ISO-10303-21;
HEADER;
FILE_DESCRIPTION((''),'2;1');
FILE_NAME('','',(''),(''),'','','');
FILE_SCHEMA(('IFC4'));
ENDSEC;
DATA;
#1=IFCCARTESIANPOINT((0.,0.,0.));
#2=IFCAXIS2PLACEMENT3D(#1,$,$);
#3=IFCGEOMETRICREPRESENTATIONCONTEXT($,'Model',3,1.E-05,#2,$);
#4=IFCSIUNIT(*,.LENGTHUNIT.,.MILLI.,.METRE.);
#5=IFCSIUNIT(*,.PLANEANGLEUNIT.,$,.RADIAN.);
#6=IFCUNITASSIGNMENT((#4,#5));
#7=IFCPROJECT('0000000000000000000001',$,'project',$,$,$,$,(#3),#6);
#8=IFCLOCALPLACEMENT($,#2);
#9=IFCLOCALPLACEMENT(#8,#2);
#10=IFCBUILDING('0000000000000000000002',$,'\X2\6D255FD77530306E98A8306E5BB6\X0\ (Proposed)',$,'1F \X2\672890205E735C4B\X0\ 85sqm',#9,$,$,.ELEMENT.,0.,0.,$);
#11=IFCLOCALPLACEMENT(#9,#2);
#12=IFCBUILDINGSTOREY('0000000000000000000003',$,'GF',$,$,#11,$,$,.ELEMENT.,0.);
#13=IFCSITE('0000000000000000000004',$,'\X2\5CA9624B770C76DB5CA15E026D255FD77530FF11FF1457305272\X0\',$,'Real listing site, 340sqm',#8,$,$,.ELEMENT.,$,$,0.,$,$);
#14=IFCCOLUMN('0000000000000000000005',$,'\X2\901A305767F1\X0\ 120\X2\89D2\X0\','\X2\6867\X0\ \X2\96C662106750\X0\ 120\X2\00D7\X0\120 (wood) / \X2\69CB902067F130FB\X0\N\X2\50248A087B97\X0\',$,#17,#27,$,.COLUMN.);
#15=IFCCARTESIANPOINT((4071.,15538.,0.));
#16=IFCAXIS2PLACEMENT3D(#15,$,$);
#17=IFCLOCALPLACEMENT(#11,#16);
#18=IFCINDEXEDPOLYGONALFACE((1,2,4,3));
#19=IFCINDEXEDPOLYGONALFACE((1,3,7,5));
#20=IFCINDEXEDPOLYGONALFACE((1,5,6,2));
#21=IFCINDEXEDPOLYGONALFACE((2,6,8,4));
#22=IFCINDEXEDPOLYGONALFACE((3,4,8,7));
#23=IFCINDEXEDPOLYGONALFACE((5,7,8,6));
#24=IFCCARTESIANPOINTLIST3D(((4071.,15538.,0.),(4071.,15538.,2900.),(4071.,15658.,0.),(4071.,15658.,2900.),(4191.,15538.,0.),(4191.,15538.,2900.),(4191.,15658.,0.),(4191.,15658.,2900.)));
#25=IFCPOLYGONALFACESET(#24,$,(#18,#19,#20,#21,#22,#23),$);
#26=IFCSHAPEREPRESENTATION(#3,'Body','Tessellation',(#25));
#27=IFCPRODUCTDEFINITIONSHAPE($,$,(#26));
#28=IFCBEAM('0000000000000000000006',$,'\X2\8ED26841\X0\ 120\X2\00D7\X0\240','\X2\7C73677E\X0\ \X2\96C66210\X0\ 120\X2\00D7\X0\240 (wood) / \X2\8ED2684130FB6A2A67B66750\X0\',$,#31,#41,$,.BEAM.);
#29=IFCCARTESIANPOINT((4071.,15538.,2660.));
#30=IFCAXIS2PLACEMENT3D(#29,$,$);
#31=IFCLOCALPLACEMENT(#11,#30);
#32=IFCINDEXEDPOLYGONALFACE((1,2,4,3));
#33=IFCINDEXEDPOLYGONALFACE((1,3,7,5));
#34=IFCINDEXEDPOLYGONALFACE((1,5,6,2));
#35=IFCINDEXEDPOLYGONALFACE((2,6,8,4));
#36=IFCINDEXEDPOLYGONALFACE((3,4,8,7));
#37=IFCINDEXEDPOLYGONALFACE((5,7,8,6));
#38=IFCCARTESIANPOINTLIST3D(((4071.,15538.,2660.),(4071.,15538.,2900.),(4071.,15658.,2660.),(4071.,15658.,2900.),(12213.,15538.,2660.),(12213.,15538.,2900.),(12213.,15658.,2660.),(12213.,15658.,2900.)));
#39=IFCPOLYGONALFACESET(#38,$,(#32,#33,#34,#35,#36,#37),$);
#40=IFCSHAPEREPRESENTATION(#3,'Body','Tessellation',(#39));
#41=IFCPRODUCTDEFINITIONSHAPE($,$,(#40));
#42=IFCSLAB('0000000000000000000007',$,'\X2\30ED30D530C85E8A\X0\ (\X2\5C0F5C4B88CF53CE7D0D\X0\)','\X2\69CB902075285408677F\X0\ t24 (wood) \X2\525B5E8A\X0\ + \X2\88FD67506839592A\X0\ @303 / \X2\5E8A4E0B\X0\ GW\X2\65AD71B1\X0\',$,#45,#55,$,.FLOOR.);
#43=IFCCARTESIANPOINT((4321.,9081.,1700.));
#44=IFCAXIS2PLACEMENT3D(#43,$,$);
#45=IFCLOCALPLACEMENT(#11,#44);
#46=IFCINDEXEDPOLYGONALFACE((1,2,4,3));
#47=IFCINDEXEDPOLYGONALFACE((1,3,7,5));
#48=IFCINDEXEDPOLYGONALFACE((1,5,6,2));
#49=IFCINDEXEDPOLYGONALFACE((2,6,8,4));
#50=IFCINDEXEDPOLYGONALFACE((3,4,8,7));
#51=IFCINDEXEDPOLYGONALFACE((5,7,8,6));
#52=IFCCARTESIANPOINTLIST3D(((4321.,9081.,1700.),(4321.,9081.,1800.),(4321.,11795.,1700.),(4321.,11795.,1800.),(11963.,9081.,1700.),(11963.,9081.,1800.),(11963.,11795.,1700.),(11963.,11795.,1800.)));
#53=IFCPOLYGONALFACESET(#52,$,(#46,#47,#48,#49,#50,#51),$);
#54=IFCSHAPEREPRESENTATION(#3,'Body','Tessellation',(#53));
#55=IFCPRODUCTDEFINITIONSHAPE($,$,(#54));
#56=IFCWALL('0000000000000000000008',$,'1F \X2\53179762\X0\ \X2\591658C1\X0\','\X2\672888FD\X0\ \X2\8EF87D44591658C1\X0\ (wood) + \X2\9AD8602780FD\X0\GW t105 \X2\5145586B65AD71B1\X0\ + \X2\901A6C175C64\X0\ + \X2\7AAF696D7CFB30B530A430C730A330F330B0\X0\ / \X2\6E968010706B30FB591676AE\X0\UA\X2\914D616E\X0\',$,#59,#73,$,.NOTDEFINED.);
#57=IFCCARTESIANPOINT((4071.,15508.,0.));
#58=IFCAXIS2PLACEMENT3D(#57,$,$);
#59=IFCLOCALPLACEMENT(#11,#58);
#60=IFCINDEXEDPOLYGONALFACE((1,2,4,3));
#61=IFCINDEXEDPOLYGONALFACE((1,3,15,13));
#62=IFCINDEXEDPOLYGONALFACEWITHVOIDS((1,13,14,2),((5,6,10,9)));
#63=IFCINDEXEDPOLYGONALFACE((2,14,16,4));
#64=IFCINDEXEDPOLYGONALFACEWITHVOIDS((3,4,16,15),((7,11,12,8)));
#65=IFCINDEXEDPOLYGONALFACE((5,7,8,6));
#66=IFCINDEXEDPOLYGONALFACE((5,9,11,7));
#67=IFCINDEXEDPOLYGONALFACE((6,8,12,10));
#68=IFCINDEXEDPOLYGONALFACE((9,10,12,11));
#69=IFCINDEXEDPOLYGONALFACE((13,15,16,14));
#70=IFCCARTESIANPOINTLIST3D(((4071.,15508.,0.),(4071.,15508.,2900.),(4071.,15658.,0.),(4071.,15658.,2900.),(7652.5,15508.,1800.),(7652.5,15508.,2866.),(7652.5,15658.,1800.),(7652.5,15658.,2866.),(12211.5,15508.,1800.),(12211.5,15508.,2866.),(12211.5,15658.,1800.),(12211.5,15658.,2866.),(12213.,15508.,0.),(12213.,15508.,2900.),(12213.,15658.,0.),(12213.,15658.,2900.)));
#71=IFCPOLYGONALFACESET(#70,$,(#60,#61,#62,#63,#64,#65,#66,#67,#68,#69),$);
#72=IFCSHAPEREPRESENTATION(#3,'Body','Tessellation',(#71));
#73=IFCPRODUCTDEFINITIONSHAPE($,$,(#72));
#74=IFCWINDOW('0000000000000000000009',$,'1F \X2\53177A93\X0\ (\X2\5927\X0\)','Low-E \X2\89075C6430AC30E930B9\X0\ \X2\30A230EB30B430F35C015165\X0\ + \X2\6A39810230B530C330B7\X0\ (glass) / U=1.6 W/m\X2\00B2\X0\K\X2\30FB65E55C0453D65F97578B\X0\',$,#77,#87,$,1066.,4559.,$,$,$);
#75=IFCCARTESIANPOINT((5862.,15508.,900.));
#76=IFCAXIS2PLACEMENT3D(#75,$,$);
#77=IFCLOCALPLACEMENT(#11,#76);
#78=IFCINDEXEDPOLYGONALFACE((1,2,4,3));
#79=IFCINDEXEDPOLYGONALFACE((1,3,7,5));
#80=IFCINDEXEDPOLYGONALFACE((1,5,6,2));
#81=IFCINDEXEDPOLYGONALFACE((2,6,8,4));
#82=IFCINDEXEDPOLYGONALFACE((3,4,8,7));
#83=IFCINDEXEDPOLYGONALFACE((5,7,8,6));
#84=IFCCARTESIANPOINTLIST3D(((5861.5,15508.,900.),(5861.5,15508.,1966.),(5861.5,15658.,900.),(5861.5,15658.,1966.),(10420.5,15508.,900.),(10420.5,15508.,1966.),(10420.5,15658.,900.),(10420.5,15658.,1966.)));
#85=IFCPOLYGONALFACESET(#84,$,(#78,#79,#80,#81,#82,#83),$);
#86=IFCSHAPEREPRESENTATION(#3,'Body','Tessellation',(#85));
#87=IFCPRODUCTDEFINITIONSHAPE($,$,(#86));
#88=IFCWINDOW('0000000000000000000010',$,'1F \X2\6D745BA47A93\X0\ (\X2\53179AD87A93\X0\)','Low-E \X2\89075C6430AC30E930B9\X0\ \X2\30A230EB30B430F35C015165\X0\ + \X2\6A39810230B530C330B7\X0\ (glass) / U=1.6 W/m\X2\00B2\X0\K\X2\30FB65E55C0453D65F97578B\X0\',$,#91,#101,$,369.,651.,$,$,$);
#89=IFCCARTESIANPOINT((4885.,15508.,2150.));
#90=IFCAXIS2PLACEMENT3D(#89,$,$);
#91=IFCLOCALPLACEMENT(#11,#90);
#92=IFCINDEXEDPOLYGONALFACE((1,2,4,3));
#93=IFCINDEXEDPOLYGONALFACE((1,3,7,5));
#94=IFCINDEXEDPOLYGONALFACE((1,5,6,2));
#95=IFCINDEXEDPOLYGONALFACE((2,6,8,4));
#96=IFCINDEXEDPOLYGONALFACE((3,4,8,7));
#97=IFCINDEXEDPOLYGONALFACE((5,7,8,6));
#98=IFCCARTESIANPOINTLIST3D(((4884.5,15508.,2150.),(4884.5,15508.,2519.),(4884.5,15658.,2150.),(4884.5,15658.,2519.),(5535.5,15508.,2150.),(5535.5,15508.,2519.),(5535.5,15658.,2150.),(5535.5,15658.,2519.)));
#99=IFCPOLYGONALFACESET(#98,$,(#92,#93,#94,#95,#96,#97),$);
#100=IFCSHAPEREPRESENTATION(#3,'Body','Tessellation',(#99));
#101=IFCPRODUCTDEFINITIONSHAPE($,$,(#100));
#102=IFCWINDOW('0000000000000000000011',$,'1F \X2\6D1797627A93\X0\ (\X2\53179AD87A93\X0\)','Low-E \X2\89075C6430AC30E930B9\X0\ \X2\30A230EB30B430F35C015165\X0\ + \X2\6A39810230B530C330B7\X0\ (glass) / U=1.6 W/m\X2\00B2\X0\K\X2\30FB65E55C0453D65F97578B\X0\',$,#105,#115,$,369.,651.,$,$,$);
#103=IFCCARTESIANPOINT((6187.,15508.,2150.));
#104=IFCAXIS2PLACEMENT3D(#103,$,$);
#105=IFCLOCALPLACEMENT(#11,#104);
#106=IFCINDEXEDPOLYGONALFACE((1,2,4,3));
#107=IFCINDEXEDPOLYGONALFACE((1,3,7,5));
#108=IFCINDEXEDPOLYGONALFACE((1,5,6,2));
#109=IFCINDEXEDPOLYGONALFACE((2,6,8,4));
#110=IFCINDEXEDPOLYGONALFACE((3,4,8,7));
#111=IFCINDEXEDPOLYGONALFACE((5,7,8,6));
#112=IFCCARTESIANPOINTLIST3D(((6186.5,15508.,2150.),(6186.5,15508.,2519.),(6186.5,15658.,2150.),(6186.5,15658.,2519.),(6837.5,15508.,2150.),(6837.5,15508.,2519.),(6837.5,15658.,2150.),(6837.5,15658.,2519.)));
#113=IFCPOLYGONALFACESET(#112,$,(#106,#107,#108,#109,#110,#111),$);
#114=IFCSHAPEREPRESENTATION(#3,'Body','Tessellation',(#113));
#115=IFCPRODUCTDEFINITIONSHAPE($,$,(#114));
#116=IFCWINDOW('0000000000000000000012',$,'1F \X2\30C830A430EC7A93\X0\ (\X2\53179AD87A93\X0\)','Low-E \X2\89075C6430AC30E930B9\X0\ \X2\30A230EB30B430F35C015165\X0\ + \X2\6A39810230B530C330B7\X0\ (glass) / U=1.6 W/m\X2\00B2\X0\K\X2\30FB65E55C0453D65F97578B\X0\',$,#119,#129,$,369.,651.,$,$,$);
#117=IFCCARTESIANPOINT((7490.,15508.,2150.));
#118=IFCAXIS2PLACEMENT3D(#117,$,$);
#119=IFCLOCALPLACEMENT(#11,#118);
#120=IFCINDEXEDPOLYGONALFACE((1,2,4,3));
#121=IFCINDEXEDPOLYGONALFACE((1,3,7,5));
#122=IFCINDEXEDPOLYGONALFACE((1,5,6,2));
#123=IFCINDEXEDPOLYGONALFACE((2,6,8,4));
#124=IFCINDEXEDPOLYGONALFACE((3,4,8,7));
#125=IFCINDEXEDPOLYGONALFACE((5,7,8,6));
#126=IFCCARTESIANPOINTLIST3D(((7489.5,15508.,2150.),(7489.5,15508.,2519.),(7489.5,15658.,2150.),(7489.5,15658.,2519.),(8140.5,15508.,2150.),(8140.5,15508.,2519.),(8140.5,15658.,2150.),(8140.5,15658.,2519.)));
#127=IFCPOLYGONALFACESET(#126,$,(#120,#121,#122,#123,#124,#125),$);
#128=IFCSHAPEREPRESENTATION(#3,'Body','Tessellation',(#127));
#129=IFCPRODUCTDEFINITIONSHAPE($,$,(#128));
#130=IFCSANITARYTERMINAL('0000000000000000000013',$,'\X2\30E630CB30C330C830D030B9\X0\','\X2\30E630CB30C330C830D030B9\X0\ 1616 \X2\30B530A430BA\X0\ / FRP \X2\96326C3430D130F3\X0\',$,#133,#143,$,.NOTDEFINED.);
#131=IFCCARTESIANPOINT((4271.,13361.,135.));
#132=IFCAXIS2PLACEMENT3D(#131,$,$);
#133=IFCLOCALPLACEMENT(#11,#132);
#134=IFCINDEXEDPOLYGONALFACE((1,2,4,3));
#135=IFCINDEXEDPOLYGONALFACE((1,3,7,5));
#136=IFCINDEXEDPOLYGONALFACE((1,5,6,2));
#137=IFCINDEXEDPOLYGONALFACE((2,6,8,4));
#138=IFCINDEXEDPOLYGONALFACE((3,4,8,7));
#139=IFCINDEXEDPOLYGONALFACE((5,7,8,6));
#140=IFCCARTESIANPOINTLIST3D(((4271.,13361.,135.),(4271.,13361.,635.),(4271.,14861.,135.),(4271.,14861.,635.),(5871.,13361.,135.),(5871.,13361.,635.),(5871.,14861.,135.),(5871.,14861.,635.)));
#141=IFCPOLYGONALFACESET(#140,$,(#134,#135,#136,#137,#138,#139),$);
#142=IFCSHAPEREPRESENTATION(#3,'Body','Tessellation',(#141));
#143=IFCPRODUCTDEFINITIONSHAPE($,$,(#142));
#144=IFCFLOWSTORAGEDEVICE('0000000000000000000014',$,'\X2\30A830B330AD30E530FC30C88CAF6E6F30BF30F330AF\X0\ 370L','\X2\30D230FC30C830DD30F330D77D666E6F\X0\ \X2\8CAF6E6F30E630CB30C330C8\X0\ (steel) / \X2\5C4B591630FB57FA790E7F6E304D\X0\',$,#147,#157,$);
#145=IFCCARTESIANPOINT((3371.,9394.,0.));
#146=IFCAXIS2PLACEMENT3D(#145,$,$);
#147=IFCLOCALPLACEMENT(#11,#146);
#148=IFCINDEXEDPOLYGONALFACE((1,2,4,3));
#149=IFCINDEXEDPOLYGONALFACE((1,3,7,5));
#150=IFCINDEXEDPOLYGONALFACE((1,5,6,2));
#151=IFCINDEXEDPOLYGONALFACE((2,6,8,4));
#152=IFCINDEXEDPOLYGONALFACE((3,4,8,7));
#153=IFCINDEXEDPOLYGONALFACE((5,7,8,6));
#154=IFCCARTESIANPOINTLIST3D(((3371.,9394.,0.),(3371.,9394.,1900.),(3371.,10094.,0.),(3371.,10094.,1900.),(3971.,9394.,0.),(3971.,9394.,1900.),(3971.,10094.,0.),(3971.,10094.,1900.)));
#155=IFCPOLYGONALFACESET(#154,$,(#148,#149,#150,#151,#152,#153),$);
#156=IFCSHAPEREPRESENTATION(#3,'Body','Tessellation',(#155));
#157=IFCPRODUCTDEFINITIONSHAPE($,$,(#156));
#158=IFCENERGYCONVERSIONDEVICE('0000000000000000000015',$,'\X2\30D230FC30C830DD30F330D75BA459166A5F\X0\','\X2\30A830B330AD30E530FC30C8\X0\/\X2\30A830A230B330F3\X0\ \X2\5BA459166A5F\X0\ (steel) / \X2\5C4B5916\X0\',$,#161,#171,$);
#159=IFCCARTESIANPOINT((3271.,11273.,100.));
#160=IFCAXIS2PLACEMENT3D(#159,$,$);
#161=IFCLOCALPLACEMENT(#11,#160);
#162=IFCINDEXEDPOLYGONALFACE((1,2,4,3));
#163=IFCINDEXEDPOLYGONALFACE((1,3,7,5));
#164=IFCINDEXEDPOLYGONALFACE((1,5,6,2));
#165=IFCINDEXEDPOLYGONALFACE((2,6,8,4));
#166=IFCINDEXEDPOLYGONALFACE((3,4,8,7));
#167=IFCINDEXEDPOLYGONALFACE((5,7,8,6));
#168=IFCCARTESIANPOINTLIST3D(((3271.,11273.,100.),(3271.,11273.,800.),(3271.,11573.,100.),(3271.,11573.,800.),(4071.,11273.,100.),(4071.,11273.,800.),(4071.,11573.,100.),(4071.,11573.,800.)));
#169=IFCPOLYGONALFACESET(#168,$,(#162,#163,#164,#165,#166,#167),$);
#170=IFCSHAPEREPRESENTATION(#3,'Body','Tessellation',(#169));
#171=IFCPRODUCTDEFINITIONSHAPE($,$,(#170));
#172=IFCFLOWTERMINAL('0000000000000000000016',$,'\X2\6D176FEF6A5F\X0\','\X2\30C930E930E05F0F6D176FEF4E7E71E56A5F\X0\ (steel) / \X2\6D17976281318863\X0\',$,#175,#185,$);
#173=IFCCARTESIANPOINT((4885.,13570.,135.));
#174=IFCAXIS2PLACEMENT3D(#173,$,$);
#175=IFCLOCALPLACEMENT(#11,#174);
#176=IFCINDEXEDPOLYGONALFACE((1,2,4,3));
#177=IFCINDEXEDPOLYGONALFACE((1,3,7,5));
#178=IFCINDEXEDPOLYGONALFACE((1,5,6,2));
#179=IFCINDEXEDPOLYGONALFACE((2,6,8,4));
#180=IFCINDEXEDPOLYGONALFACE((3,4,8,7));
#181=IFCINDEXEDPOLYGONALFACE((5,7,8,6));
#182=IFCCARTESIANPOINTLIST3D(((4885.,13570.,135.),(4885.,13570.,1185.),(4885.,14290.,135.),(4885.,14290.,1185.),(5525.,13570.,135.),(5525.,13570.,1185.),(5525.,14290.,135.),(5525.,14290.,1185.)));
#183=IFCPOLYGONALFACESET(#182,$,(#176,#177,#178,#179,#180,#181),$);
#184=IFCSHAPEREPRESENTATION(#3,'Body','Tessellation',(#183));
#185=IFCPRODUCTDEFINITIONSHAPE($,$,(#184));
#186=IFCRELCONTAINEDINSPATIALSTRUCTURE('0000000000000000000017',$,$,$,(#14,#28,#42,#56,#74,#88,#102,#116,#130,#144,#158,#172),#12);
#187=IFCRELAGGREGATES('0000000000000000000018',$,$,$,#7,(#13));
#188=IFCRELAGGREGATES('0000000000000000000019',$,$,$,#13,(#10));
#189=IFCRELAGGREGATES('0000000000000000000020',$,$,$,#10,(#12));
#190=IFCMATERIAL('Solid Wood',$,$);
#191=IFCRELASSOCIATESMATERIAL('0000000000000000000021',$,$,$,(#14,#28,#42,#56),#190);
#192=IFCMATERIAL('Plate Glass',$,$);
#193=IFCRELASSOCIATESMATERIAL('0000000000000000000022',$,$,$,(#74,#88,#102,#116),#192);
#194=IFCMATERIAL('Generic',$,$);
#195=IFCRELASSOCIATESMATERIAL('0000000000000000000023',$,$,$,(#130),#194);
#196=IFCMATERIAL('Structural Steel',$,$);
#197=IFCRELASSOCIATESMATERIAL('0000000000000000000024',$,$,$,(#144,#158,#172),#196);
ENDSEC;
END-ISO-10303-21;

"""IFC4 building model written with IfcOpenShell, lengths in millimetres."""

from ifc_helpers import new_model, si_unit, frame, frame_2d, origin, place, context, project, spatial, rectangle, extrude, material, element, fill, save


model = new_model("IFC4")

# Units and contexts
model_context = context("Model", 3, precision=1e-05, world=origin())
ifc_project = project(units=[si_unit("LENGTHUNIT", "METRE", prefix="MILLI"), si_unit("PLANEANGLEUNIT", "RADIAN")], contexts=[model_context])

# Site, building, storey
site_placement = place(None, origin())
site = spatial("IfcSite", under=ifc_project, at=site_placement, Name="岩手県盛岡市津志田１４地割", ObjectType="Real listing site, 340sqm", CompositionType="ELEMENT", RefElevation=0.0)
building_placement = place(site_placement, origin())
building = spatial("IfcBuilding", under=site, at=building_placement, Name="津志田の風の家 (Proposed)", ObjectType="1F 木造平屋 85sqm", CompositionType="ELEMENT", ElevationOfRefHeight=0.0, ElevationOfTerrain=0.0)
storey_placement = place(building_placement, origin())
storey = spatial("IfcBuildingStorey", under=building, at=storey_placement, Name="GF", CompositionType="ELEMENT", Elevation=0.0)

# Column
ifc_material_1 = material(Name="Solid Wood")
column_1_placement = place(storey_placement, frame((4071.0, 15538.0, 0.0)))
element("IfcColumn", 1, at=column_1_placement, inside=storey, material=ifc_material_1, Name="通し柱 120角", Description="桧 集成材 120×120 (wood) / 構造柱・N値計算", PredefinedType="COLUMN", context=model_context, shape_type="SweptSolid", body=[
    extrude(rectangle(XDim=120.0, YDim=120.0, at=frame_2d((60.0, 60.0))), frame((4071.0, 15538.0, 0.0)), (0.0, 0.0, 1.0), 2900.0),
])

# Beam
beam_1_placement = place(storey_placement, frame((4071.0, 15538.0, 2660.0)))
element("IfcBeam", 2, at=beam_1_placement, inside=storey, material=ifc_material_1, Name="軒桁 120×240", Description="米松 集成 120×240 (wood) / 軒桁・横架材", PredefinedType="BEAM", context=model_context, shape_type="SweptSolid", body=[
    extrude(rectangle(XDim=8142.0, YDim=120.0, at=frame_2d((4071.0, 60.0))), frame((4071.0, 15538.0, 2660.0)), (0.0, 0.0, 1.0), 240.0),
])

# Slab
slab_placement = place(storey_placement, frame((4321.0, 9081.0, 1700.0)))
element("IfcSlab", 3, at=slab_placement, inside=storey, material=ifc_material_1, Name="ロフト床 (小屋裏収納)", Description="構造用合板 t24 (wood) 剛床 + 製材根太 @303 / 床下 GW断熱", PredefinedType="FLOOR", context=model_context, shape_type="SweptSolid", body=[
    extrude(rectangle(XDim=7642.0, YDim=2714.0, at=frame_2d((3821.0, 1357.0))), frame((4321.0, 9081.0, 1700.0)), (0.0, 0.0, 1.0), 100.0),
])

# Wall, openings, windows
wall_1_placement = place(storey_placement, frame((4071.0, 15508.0, 0.0)))
wall_1 = element("IfcWall", 4, at=wall_1_placement, inside=storey, material=ifc_material_1, Name="1F 北面 外壁", Description="木製 軸組外壁 (wood) + 高性能GW t105 充填断熱 + 通気層 + 窯業系サイディング / 準耐火・外皮UA配慮", PredefinedType="NOTDEFINED", context=model_context, shape_type="SweptSolid", body=[
    extrude(rectangle(XDim=8142.0, YDim=150.0, at=frame_2d((4071.0, 75.0))), frame((4071.0, 15508.0, 0.0)), (0.0, 0.0, 1.0), 2900.0),
])
opening_1_placement = place(storey_placement, frame((5862.0, 15508.0, 900.0)))
opening_1 = element("IfcOpeningElement", 5, at=opening_1_placement, cuts=wall_1, PredefinedType="NOTDEFINED", context=model_context, shape_type="SweptSolid", body=[
    extrude(rectangle(XDim=4559.0, YDim=150.0, at=frame_2d((2279.0, 75.0))), frame((5862.0, 15508.0, 900.0)), (0.0, 0.0, 1.0), 1066.0),
])
opening_2_placement = place(storey_placement, frame((4885.0, 15508.0, 2150.0)))
opening_2 = element("IfcOpeningElement", 6, at=opening_2_placement, cuts=wall_1, PredefinedType="NOTDEFINED", context=model_context, shape_type="SweptSolid", body=[
    extrude(rectangle(XDim=651.0, YDim=150.0, at=frame_2d((325.0, 75.0))), frame((4885.0, 15508.0, 2150.0)), (0.0, 0.0, 1.0), 369.0),
])
opening_3_placement = place(storey_placement, frame((6187.0, 15508.0, 2150.0)))
opening_3 = element("IfcOpeningElement", 7, at=opening_3_placement, cuts=wall_1, PredefinedType="NOTDEFINED", context=model_context, shape_type="SweptSolid", body=[
    extrude(rectangle(XDim=651.0, YDim=150.0, at=frame_2d((325.0, 75.0))), frame((6187.0, 15508.0, 2150.0)), (0.0, 0.0, 1.0), 369.0),
])
opening_4_placement = place(storey_placement, frame((7490.0, 15508.0, 2150.0)))
opening_4 = element("IfcOpeningElement", 8, at=opening_4_placement, cuts=wall_1, PredefinedType="NOTDEFINED", context=model_context, shape_type="SweptSolid", body=[
    extrude(rectangle(XDim=651.0, YDim=150.0, at=frame_2d((325.0, 75.0))), frame((7490.0, 15508.0, 2150.0)), (0.0, 0.0, 1.0), 369.0),
])
ifc_material_2 = material(Name="Plate Glass")
window_1_placement = place(storey_placement, frame((5862.0, 15508.0, 900.0)))
window_1 = element("IfcWindow", 9, at=window_1_placement, inside=storey, material=ifc_material_2, Name="1F 北窓 (大)", Description="Low-E 複層ガラス アルゴン封入 + 樹脂サッシ (glass) / U=1.6 W/m²K・日射取得型", OverallHeight=1066.0, OverallWidth=4559.0, context=model_context, shape_type="SweptSolid", body=[
    extrude(rectangle(XDim=4559.0, YDim=150.0, at=frame_2d((2279.0, 75.0))), frame((5862.0, 15508.0, 900.0)), (0.0, 0.0, 1.0), 1066.0),
])
fill(opening_1, window_1)
window_2_placement = place(storey_placement, frame((4885.0, 15508.0, 2150.0)))
window_2 = element("IfcWindow", 10, at=window_2_placement, inside=storey, material=ifc_material_2, Name="1F 浴室窓 (北高窓)", Description="Low-E 複層ガラス アルゴン封入 + 樹脂サッシ (glass) / U=1.6 W/m²K・日射取得型", OverallHeight=369.0, OverallWidth=651.0, context=model_context, shape_type="SweptSolid", body=[
    extrude(rectangle(XDim=651.0, YDim=150.0, at=frame_2d((325.0, 75.0))), frame((4885.0, 15508.0, 2150.0)), (0.0, 0.0, 1.0), 369.0),
])
fill(opening_2, window_2)
window_3_placement = place(storey_placement, frame((6187.0, 15508.0, 2150.0)))
window_3 = element("IfcWindow", 11, at=window_3_placement, inside=storey, material=ifc_material_2, Name="1F 洗面窓 (北高窓)", Description="Low-E 複層ガラス アルゴン封入 + 樹脂サッシ (glass) / U=1.6 W/m²K・日射取得型", OverallHeight=369.0, OverallWidth=651.0, context=model_context, shape_type="SweptSolid", body=[
    extrude(rectangle(XDim=651.0, YDim=150.0, at=frame_2d((325.0, 75.0))), frame((6187.0, 15508.0, 2150.0)), (0.0, 0.0, 1.0), 369.0),
])
fill(opening_3, window_3)
window_4_placement = place(storey_placement, frame((7490.0, 15508.0, 2150.0)))
window_4 = element("IfcWindow", 12, at=window_4_placement, inside=storey, material=ifc_material_2, Name="1F トイレ窓 (北高窓)", Description="Low-E 複層ガラス アルゴン封入 + 樹脂サッシ (glass) / U=1.6 W/m²K・日射取得型", OverallHeight=369.0, OverallWidth=651.0, context=model_context, shape_type="SweptSolid", body=[
    extrude(rectangle(XDim=651.0, YDim=150.0, at=frame_2d((325.0, 75.0))), frame((7490.0, 15508.0, 2150.0)), (0.0, 0.0, 1.0), 369.0),
])
fill(opening_4, window_4)

# Sanitary terminal
ifc_material_3 = material(Name="Generic")
sanitary_terminal_placement = place(storey_placement, frame((4271.0, 13361.0, 135.0)))
element("IfcSanitaryTerminal", 13, at=sanitary_terminal_placement, inside=storey, material=ifc_material_3, Name="ユニットバス", Description="ユニットバス 1616 サイズ / FRP 防水パン", PredefinedType="NOTDEFINED", context=model_context, shape_type="SweptSolid", body=[
    extrude(rectangle(XDim=1600.0, YDim=1500.0, at=frame_2d((800.0, 750.0))), frame((4271.0, 13361.0, 135.0)), (0.0, 0.0, 1.0), 500.0),
])

# Flow storage device
ifc_material_4 = material(Name="Structural Steel")
flow_storage_device_placement = place(storey_placement, frame((3371.0, 9394.0, 0.0)))
element("IfcFlowStorageDevice", 14, at=flow_storage_device_placement, inside=storey, material=ifc_material_4, Name="エコキュート貯湯タンク 370L", Description="ヒートポンプ給湯 貯湯ユニット (steel) / 屋外・基礎置き", context=model_context, shape_type="SweptSolid", body=[
    extrude(rectangle(XDim=600.0, YDim=700.0, at=frame_2d((300.0, 350.0))), frame((3371.0, 9394.0, 0.0)), (0.0, 0.0, 1.0), 1900.0),
])

# Energy conversion device
energy_conversion_device_placement = place(storey_placement, frame((3271.0, 11273.0, 100.0)))
element("IfcEnergyConversionDevice", 15, at=energy_conversion_device_placement, inside=storey, material=ifc_material_4, Name="ヒートポンプ室外機", Description="エコキュート/エアコン 室外機 (steel) / 屋外", context=model_context, shape_type="SweptSolid", body=[
    extrude(rectangle(XDim=800.0, YDim=300.0, at=frame_2d((400.0, 150.0))), frame((3271.0, 11273.0, 100.0)), (0.0, 0.0, 1.0), 700.0),
])

# Flow terminal
flow_terminal_placement = place(storey_placement, frame((4885.0, 13570.0, 135.0)))
element("IfcFlowTerminal", 16, at=flow_terminal_placement, inside=storey, material=ifc_material_4, Name="洗濯機", Description="ドラム式洗濯乾燥機 (steel) / 洗面脱衣", context=model_context, shape_type="SweptSolid", body=[
    extrude(rectangle(XDim=640.0, YDim=720.0, at=frame_2d((320.0, 360.0))), frame((4885.0, 13570.0, 135.0)), (0.0, 0.0, 1.0), 1050.0),
])

save(model, "model.ifc")
